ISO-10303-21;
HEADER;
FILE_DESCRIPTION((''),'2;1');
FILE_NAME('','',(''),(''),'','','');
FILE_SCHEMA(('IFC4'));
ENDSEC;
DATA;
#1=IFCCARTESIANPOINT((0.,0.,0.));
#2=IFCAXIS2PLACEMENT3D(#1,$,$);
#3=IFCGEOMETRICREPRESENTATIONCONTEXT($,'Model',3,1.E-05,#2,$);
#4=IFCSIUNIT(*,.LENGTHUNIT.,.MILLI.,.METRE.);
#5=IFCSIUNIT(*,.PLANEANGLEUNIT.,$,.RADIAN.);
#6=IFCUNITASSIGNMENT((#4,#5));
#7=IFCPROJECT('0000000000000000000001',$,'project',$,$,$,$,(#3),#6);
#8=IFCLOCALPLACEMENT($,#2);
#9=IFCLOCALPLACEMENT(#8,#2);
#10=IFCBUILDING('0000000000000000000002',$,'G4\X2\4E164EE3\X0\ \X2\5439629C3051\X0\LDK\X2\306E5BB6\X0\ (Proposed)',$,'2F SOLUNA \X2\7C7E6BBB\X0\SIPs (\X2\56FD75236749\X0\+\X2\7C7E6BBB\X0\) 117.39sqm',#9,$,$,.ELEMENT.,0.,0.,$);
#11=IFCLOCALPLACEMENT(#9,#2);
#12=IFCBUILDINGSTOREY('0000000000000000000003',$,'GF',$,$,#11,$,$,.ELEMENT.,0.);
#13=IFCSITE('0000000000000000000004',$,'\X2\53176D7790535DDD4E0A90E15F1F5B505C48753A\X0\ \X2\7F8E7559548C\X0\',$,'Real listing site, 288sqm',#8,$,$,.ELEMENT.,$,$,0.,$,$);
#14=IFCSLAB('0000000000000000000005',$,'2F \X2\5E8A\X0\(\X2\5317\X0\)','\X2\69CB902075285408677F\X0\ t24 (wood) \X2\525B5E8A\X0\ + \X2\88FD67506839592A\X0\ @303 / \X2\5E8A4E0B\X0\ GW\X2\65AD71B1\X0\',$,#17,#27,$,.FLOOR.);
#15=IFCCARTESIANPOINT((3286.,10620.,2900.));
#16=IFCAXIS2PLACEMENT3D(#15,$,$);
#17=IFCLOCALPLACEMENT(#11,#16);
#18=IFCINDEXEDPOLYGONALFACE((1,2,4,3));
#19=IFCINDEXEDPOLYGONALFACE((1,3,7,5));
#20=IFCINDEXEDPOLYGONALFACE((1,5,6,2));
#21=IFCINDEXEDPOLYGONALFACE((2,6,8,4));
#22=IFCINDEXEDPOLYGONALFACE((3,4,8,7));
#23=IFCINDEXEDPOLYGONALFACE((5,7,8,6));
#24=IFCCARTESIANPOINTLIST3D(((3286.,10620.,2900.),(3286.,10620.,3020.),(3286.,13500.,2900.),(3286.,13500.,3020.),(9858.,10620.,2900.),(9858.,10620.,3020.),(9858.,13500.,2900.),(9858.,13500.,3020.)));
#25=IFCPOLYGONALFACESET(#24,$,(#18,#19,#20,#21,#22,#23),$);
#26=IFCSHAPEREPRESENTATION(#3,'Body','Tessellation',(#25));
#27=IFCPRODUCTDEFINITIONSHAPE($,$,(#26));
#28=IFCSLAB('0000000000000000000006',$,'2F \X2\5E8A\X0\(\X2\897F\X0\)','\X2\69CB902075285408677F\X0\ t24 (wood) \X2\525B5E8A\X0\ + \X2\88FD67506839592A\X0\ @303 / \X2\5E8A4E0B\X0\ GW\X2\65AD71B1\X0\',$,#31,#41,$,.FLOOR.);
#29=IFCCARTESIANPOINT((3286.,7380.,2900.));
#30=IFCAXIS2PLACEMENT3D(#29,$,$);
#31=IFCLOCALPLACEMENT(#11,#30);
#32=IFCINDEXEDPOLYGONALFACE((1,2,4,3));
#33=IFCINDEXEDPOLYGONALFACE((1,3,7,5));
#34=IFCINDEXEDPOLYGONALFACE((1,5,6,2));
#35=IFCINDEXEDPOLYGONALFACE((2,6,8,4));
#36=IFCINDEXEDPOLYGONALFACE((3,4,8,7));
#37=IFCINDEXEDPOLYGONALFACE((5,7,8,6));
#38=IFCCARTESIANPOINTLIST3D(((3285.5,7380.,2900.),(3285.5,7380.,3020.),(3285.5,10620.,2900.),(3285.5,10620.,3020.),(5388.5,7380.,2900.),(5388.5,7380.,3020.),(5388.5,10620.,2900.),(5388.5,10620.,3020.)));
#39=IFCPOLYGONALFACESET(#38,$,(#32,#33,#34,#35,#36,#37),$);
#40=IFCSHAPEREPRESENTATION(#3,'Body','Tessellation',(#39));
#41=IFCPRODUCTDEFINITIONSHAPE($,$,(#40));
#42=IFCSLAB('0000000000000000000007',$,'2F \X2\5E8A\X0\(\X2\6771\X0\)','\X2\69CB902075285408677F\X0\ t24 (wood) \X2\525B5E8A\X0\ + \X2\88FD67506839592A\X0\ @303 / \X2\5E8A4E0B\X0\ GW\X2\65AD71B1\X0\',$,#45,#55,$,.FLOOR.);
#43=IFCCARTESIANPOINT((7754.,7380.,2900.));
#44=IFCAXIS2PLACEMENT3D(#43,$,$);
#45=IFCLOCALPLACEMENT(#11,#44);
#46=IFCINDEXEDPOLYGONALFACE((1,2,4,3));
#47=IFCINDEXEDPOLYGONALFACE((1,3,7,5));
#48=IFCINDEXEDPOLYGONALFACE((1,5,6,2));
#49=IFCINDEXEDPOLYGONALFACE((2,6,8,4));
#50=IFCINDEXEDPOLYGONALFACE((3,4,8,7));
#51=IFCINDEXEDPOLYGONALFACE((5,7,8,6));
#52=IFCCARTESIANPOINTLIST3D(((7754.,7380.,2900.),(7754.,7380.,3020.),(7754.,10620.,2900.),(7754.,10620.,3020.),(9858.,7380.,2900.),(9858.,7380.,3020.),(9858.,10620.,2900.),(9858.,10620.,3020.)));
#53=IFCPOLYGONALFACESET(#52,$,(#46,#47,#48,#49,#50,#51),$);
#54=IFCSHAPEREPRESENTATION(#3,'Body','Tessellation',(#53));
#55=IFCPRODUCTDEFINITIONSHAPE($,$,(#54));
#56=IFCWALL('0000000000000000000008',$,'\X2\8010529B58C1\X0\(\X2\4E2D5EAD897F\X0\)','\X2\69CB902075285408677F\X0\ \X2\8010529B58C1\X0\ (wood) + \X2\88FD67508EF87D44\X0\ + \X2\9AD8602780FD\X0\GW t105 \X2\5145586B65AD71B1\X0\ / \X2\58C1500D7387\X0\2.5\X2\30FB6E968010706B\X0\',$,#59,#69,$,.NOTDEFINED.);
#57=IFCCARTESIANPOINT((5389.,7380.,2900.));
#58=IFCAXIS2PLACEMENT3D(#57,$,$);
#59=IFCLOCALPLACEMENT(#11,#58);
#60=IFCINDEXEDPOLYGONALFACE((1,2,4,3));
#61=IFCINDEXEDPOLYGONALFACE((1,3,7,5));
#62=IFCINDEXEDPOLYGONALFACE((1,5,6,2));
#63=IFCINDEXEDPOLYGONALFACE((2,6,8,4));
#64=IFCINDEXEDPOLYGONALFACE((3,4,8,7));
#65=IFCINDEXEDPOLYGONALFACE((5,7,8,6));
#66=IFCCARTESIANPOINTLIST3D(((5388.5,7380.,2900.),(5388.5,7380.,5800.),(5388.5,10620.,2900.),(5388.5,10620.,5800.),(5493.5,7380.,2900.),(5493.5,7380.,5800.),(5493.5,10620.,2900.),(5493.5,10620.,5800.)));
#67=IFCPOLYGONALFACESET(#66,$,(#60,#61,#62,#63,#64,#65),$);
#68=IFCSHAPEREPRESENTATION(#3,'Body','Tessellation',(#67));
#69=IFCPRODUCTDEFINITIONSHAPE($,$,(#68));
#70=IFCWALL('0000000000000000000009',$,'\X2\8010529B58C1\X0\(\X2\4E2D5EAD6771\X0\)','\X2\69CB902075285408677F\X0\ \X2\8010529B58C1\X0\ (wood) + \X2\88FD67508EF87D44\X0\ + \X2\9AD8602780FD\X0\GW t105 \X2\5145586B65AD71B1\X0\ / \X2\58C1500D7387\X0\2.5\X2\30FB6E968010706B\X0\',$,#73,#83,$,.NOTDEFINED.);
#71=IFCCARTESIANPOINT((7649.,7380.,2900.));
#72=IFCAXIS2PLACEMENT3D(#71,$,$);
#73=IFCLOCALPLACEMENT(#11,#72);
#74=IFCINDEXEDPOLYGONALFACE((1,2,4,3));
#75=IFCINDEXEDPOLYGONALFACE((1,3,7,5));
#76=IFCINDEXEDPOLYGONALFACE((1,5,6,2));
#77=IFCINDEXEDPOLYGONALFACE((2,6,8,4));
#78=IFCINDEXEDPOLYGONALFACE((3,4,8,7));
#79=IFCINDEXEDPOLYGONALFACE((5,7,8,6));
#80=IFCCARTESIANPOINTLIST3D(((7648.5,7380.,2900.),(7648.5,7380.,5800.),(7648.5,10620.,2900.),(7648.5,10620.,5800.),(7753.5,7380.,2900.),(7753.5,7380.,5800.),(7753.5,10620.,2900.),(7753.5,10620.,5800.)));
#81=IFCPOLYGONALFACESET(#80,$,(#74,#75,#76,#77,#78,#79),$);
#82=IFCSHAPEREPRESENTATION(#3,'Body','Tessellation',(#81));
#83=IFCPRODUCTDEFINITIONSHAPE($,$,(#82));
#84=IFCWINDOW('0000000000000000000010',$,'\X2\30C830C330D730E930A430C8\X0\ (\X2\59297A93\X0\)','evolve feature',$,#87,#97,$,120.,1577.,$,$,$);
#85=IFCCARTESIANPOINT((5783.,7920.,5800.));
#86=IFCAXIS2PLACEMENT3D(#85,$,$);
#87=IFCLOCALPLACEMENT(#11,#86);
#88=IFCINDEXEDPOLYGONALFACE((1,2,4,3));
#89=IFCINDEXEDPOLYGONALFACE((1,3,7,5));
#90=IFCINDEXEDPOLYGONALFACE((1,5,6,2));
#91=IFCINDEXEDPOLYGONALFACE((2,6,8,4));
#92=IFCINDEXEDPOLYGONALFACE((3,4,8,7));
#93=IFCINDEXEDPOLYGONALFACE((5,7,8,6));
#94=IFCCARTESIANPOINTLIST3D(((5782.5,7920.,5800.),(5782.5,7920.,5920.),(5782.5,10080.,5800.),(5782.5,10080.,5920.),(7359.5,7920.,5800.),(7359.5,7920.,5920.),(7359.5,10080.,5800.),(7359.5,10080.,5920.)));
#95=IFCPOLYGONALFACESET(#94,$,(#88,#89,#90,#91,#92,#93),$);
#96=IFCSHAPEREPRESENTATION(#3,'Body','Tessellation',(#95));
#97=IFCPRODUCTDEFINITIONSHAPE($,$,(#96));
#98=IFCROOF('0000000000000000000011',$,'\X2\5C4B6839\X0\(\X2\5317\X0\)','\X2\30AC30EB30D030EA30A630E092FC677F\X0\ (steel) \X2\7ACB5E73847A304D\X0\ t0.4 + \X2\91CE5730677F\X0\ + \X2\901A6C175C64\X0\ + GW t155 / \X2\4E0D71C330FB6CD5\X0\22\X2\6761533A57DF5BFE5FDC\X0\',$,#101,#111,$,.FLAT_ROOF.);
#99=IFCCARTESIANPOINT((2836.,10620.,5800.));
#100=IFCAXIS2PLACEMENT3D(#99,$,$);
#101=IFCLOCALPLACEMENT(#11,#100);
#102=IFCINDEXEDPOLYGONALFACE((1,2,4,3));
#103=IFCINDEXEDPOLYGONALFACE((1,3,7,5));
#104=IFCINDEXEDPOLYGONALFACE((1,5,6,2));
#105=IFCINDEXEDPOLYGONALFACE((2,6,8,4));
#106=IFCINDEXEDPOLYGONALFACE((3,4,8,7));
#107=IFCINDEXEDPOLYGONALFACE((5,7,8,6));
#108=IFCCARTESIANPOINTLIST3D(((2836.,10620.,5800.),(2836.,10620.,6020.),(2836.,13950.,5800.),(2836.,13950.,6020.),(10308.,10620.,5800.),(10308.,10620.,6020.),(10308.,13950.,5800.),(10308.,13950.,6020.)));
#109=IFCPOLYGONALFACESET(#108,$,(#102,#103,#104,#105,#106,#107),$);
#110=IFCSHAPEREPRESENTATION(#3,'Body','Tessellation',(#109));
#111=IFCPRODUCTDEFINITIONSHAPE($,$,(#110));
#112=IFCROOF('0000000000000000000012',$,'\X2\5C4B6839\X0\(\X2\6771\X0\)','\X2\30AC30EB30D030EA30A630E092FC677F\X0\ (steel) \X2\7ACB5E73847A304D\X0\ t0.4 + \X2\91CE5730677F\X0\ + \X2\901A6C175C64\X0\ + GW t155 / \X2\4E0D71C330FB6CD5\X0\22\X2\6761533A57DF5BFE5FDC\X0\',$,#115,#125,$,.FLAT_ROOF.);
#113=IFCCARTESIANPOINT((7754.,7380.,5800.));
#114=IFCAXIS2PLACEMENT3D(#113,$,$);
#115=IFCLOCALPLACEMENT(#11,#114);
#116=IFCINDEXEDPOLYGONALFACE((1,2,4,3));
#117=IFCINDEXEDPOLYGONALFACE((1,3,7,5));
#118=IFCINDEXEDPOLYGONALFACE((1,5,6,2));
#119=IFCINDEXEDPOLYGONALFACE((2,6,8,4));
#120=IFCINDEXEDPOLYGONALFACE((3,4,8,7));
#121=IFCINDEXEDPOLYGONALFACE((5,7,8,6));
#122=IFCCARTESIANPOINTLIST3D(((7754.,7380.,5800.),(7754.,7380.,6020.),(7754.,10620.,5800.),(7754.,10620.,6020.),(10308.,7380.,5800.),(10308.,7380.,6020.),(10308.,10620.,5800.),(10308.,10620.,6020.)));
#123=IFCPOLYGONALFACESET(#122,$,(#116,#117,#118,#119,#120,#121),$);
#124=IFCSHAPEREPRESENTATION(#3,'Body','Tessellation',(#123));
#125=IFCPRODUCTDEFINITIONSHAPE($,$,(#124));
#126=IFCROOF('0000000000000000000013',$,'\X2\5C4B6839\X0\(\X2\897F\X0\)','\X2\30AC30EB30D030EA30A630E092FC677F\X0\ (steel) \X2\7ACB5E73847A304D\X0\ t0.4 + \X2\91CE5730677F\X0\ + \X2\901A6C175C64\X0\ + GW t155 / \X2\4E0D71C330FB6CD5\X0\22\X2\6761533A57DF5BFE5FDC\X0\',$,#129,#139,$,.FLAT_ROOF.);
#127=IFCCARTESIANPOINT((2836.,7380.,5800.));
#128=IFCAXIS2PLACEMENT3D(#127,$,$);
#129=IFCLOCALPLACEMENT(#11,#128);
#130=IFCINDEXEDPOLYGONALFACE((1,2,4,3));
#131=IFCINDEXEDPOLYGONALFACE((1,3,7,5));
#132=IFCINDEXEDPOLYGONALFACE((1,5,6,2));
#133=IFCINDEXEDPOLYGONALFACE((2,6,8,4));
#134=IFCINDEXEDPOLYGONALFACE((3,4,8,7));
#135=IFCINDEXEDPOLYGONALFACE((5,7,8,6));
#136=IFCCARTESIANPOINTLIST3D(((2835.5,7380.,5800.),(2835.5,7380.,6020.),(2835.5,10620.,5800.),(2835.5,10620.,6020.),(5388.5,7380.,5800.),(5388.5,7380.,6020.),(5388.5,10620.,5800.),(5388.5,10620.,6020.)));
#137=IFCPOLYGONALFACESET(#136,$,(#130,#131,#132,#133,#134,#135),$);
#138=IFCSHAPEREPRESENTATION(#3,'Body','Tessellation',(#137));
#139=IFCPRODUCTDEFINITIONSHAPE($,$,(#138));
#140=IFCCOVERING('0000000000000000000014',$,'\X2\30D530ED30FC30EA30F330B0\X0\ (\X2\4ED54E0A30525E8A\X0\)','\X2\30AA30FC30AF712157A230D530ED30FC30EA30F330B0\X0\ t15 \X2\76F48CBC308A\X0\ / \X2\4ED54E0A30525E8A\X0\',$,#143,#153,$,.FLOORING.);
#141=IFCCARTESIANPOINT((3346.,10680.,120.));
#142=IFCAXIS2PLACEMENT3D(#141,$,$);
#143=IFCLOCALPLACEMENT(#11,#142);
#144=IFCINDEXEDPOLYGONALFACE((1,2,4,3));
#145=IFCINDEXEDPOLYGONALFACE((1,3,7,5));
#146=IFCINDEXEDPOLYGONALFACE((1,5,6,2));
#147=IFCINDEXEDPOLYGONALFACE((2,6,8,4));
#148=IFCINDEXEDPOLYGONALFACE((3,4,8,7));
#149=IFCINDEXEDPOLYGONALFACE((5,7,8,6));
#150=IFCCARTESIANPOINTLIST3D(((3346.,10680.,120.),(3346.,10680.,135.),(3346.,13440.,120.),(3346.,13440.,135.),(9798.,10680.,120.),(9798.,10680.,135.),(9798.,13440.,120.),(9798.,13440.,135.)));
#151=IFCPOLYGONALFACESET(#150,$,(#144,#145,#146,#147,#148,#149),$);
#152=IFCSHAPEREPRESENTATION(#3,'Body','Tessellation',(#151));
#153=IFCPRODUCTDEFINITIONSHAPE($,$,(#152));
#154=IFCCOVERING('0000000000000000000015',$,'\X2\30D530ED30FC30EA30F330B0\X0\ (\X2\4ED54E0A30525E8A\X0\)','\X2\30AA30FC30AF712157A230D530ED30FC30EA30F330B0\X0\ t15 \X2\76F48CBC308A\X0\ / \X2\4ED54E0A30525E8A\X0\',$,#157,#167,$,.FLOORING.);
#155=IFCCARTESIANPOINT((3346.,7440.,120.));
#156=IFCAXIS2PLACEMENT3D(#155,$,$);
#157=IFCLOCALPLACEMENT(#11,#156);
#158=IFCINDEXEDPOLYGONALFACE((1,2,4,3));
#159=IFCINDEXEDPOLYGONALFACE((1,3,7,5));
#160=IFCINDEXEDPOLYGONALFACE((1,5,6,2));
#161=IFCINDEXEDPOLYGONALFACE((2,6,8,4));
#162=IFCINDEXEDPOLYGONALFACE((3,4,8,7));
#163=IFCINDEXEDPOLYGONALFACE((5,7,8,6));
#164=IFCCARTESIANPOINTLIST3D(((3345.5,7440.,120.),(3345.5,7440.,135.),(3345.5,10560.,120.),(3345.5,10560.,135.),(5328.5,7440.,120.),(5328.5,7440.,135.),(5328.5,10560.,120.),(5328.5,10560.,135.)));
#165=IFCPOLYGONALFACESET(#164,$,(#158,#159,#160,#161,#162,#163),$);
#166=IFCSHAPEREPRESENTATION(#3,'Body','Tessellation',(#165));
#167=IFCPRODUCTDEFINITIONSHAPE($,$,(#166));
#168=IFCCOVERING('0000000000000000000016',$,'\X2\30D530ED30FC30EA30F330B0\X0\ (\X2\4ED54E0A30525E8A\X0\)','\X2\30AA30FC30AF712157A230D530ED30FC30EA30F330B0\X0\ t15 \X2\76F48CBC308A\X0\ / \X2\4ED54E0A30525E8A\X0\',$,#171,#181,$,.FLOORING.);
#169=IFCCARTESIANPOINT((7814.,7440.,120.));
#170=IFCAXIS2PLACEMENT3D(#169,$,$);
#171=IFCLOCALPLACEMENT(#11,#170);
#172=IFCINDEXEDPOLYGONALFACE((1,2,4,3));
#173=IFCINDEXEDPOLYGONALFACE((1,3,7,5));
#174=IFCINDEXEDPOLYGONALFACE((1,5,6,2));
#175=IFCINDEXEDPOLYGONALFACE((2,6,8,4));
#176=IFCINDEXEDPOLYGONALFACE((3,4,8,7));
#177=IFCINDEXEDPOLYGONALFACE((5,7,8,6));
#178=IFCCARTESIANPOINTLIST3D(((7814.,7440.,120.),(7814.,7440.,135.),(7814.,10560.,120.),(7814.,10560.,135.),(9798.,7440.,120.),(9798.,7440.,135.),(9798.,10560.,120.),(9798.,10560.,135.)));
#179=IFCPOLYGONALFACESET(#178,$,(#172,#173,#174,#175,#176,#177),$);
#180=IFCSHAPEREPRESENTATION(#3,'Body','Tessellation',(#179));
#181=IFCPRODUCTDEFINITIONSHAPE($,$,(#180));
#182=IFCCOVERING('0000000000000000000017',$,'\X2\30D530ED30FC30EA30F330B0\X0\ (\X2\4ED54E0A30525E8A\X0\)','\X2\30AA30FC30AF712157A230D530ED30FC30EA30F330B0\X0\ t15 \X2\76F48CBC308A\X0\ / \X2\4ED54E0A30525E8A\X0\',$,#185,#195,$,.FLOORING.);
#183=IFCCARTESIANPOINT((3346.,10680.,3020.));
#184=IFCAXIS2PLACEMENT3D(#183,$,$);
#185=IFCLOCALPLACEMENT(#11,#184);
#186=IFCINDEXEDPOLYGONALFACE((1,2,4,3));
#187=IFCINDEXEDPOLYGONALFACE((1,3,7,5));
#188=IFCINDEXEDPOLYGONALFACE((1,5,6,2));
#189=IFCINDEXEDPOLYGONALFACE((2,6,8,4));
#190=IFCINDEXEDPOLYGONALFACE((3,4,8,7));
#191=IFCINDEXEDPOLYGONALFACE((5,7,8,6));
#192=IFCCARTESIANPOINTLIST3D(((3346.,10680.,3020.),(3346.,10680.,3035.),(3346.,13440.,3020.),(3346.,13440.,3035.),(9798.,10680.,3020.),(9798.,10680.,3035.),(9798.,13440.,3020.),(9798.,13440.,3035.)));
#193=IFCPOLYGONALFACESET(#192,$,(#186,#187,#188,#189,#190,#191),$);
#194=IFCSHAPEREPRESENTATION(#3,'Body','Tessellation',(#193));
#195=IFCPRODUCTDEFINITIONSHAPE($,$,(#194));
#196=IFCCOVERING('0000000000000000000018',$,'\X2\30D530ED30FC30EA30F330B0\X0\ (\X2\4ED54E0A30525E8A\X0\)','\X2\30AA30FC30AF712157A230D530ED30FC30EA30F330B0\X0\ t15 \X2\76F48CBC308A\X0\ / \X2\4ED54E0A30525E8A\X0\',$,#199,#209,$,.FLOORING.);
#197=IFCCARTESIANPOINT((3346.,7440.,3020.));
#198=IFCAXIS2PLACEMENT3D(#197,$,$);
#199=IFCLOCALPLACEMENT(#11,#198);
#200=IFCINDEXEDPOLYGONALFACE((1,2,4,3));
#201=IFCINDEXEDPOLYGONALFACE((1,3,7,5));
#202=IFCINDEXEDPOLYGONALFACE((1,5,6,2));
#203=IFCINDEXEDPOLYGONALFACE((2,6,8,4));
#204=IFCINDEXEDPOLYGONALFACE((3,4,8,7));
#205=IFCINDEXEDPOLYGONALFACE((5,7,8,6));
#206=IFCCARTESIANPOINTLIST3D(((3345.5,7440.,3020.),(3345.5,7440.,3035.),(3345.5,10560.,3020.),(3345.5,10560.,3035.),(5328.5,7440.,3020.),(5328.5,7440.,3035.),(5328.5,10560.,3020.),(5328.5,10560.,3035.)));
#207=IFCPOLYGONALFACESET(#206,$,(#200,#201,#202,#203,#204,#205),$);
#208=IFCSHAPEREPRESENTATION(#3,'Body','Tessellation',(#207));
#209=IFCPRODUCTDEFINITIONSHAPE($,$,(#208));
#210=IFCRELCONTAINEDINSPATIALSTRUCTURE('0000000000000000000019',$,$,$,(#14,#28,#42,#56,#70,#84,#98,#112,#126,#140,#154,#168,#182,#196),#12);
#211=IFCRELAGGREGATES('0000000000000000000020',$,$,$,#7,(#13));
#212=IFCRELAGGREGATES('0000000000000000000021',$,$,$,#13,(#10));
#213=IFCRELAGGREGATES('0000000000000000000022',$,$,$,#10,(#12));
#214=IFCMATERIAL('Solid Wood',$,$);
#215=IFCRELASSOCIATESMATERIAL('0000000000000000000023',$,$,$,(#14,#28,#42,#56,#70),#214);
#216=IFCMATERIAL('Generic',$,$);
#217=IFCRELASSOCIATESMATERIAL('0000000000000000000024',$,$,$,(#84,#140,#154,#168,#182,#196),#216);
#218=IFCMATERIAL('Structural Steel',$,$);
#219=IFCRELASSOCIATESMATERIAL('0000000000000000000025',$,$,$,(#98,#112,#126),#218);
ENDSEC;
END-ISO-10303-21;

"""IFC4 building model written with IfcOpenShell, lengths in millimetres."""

from ifc_helpers import new_model, si_unit, frame, frame_2d, origin, place, context, project, spatial, rectangle, extrude, material, element, save


model = new_model("IFC4")

# Units and contexts
model_context = context("Model", 3, precision=1e-05, world=origin())
ifc_project = project(units=[si_unit("LENGTHUNIT", "METRE", prefix="MILLI"), si_unit("PLANEANGLEUNIT", "RADIAN")], contexts=[model_context])

# Site, building, storey
site_placement = place(None, origin())
site = spatial("IfcSite", under=ifc_project, at=site_placement, Name="北海道川上郡弟子屈町 美留和", ObjectType="Real listing site, 288sqm", CompositionType="ELEMENT", RefElevation=0.0)
building_placement = place(site_placement, origin())
building = spatial("IfcBuilding", under=site, at=building_placement, Name="G4世代 吹抜けLDKの家 (Proposed)", ObjectType="2F SOLUNA 籾殻SIPs (国産杉+籾殻) 117.39sqm", CompositionType="ELEMENT", ElevationOfRefHeight=0.0, ElevationOfTerrain=0.0)
storey_placement = place(building_placement, origin())
storey = spatial("IfcBuildingStorey", under=building, at=storey_placement, Name="GF", CompositionType="ELEMENT", Elevation=0.0)

# Slabs
ifc_material_1 = material(Name="Solid Wood")
slab_1_placement = place(storey_placement, frame((3286.0, 10620.0, 2900.0)))
element("IfcSlab", 1, at=slab_1_placement, inside=storey, material=ifc_material_1, Name="2F 床(北)", Description="構造用合板 t24 (wood) 剛床 + 製材根太 @303 / 床下 GW断熱", PredefinedType="FLOOR", context=model_context, shape_type="SweptSolid", body=[
    extrude(rectangle(XDim=6572.0, YDim=2880.0, at=frame_2d((3286.0, 1440.0))), frame((3286.0, 10620.0, 2900.0)), (0.0, 0.0, 1.0), 120.0),
])
slab_2_placement = place(storey_placement, frame((3286.0, 7380.0, 2900.0)))
element("IfcSlab", 2, at=slab_2_placement, inside=storey, material=ifc_material_1, Name="2F 床(西)", Description="構造用合板 t24 (wood) 剛床 + 製材根太 @303 / 床下 GW断熱", PredefinedType="FLOOR", context=model_context, shape_type="SweptSolid", body=[
    extrude(rectangle(XDim=2103.0, YDim=3240.0, at=frame_2d((1051.0, 1620.0))), frame((3286.0, 7380.0, 2900.0)), (0.0, 0.0, 1.0), 120.0),
])
slab_3_placement = place(storey_placement, frame((7754.0, 7380.0, 2900.0)))
element("IfcSlab", 3, at=slab_3_placement, inside=storey, material=ifc_material_1, Name="2F 床(東)", Description="構造用合板 t24 (wood) 剛床 + 製材根太 @303 / 床下 GW断熱", PredefinedType="FLOOR", context=model_context, shape_type="SweptSolid", body=[
    extrude(rectangle(XDim=2104.0, YDim=3240.0, at=frame_2d((1052.0, 1620.0))), frame((7754.0, 7380.0, 2900.0)), (0.0, 0.0, 1.0), 120.0),
])

# Walls
wall_1_placement = place(storey_placement, frame((5389.0, 7380.0, 2900.0)))
element("IfcWall", 4, at=wall_1_placement, inside=storey, material=ifc_material_1, Name="耐力壁(中庭西)", Description="構造用合板 耐力壁 (wood) + 製材軸組 + 高性能GW t105 充填断熱 / 壁倍率2.5・準耐火", PredefinedType="NOTDEFINED", context=model_context, shape_type="SweptSolid", body=[
    extrude(rectangle(XDim=105.0, YDim=3240.0, at=frame_2d((52.0, 1620.0))), frame((5389.0, 7380.0, 2900.0)), (0.0, 0.0, 1.0), 2900.0),
])
wall_2_placement = place(storey_placement, frame((7649.0, 7380.0, 2900.0)))
element("IfcWall", 5, at=wall_2_placement, inside=storey, material=ifc_material_1, Name="耐力壁(中庭東)", Description="構造用合板 耐力壁 (wood) + 製材軸組 + 高性能GW t105 充填断熱 / 壁倍率2.5・準耐火", PredefinedType="NOTDEFINED", context=model_context, shape_type="SweptSolid", body=[
    extrude(rectangle(XDim=105.0, YDim=3240.0, at=frame_2d((52.0, 1620.0))), frame((7649.0, 7380.0, 2900.0)), (0.0, 0.0, 1.0), 2900.0),
])

# Window
ifc_material_2 = material(Name="Generic")
window_1_placement = place(storey_placement, frame((5783.0, 7920.0, 5800.0)))
element("IfcWindow", 6, at=window_1_placement, inside=storey, material=ifc_material_2, Name="トップライト (天窓)", Description="evolve feature", OverallHeight=120.0, OverallWidth=1577.0, context=model_context, shape_type="SweptSolid", body=[
    extrude(rectangle(XDim=1577.0, YDim=2160.0, at=frame_2d((788.0, 1080.0))), frame((5783.0, 7920.0, 5800.0)), (0.0, 0.0, 1.0), 120.0),
])

# Roofs
ifc_material_3 = material(Name="Structural Steel")
roof_1_placement = place(storey_placement, frame((2836.0, 10620.0, 5800.0)))
element("IfcRoof", 7, at=roof_1_placement, inside=storey, material=ifc_material_3, Name="屋根(北)", Description="ガルバリウム鋼板 (steel) 立平葺き t0.4 + 野地板 + 通気層 + GW t155 / 不燃・法22条区域対応", PredefinedType="FLAT_ROOF", context=model_context, shape_type="SweptSolid", body=[
    extrude(rectangle(XDim=7472.0, YDim=3330.0, at=frame_2d((3736.0, 1665.0))), frame((2836.0, 10620.0, 5800.0)), (0.0, 0.0, 1.0), 220.0),
])
roof_2_placement = place(storey_placement, frame((7754.0, 7380.0, 5800.0)))
element("IfcRoof", 8, at=roof_2_placement, inside=storey, material=ifc_material_3, Name="屋根(東)", Description="ガルバリウム鋼板 (steel) 立平葺き t0.4 + 野地板 + 通気層 + GW t155 / 不燃・法22条区域対応", PredefinedType="FLAT_ROOF", context=model_context, shape_type="SweptSolid", body=[
    extrude(rectangle(XDim=2554.0, YDim=3240.0, at=frame_2d((1277.0, 1620.0))), frame((7754.0, 7380.0, 5800.0)), (0.0, 0.0, 1.0), 220.0),
])
roof_3_placement = place(storey_placement, frame((2836.0, 7380.0, 5800.0)))
element("IfcRoof", 9, at=roof_3_placement, inside=storey, material=ifc_material_3, Name="屋根(西)", Description="ガルバリウム鋼板 (steel) 立平葺き t0.4 + 野地板 + 通気層 + GW t155 / 不燃・法22条区域対応", PredefinedType="FLAT_ROOF", context=model_context, shape_type="SweptSolid", body=[
    extrude(rectangle(XDim=2553.0, YDim=3240.0, at=frame_2d((1276.0, 1620.0))), frame((2836.0, 7380.0, 5800.0)), (0.0, 0.0, 1.0), 220.0),
])

# Coverings
covering_1_placement = place(storey_placement, frame((3346.0, 10680.0, 120.0)))
element("IfcCovering", 10, at=covering_1_placement, inside=storey, material=ifc_material_2, Name="フローリング (仕上げ床)", Description="オーク無垢フローリング t15 直貼り / 仕上げ床", PredefinedType="FLOORING", context=model_context, shape_type="SweptSolid", body=[
    extrude(rectangle(XDim=6452.0, YDim=2760.0, at=frame_2d((3226.0, 1380.0))), frame((3346.0, 10680.0, 120.0)), (0.0, 0.0, 1.0), 15.0),
])
covering_2_placement = place(storey_placement, frame((3346.0, 7440.0, 120.0)))
element("IfcCovering", 11, at=covering_2_placement, inside=storey, material=ifc_material_2, Name="フローリング (仕上げ床)", Description="オーク無垢フローリング t15 直貼り / 仕上げ床", PredefinedType="FLOORING", context=model_context, shape_type="SweptSolid", body=[
    extrude(rectangle(XDim=1983.0, YDim=3120.0, at=frame_2d((991.0, 1560.0))), frame((3346.0, 7440.0, 120.0)), (0.0, 0.0, 1.0), 15.0),
])
covering_3_placement = place(storey_placement, frame((7814.0, 7440.0, 120.0)))
element("IfcCovering", 12, at=covering_3_placement, inside=storey, material=ifc_material_2, Name="フローリング (仕上げ床)", Description="オーク無垢フローリング t15 直貼り / 仕上げ床", PredefinedType="FLOORING", context=model_context, shape_type="SweptSolid", body=[
    extrude(rectangle(XDim=1984.0, YDim=3120.0, at=frame_2d((992.0, 1560.0))), frame((7814.0, 7440.0, 120.0)), (0.0, 0.0, 1.0), 15.0),
])
covering_4_placement = place(storey_placement, frame((3346.0, 10680.0, 3020.0)))
element("IfcCovering", 13, at=covering_4_placement, inside=storey, material=ifc_material_2, Name="フローリング (仕上げ床)", Description="オーク無垢フローリング t15 直貼り / 仕上げ床", PredefinedType="FLOORING", context=model_context, shape_type="SweptSolid", body=[
    extrude(rectangle(XDim=6452.0, YDim=2760.0, at=frame_2d((3226.0, 1380.0))), frame((3346.0, 10680.0, 3020.0)), (0.0, 0.0, 1.0), 15.0),
])
covering_5_placement = place(storey_placement, frame((3346.0, 7440.0, 3020.0)))
element("IfcCovering", 14, at=covering_5_placement, inside=storey, material=ifc_material_2, Name="フローリング (仕上げ床)", Description="オーク無垢フローリング t15 直貼り / 仕上げ床", PredefinedType="FLOORING", context=model_context, shape_type="SweptSolid", body=[
    extrude(rectangle(XDim=1983.0, YDim=3120.0, at=frame_2d((991.0, 1560.0))), frame((3346.0, 7440.0, 3020.0)), (0.0, 0.0, 1.0), 15.0),
])

save(model, "model.ifc")
